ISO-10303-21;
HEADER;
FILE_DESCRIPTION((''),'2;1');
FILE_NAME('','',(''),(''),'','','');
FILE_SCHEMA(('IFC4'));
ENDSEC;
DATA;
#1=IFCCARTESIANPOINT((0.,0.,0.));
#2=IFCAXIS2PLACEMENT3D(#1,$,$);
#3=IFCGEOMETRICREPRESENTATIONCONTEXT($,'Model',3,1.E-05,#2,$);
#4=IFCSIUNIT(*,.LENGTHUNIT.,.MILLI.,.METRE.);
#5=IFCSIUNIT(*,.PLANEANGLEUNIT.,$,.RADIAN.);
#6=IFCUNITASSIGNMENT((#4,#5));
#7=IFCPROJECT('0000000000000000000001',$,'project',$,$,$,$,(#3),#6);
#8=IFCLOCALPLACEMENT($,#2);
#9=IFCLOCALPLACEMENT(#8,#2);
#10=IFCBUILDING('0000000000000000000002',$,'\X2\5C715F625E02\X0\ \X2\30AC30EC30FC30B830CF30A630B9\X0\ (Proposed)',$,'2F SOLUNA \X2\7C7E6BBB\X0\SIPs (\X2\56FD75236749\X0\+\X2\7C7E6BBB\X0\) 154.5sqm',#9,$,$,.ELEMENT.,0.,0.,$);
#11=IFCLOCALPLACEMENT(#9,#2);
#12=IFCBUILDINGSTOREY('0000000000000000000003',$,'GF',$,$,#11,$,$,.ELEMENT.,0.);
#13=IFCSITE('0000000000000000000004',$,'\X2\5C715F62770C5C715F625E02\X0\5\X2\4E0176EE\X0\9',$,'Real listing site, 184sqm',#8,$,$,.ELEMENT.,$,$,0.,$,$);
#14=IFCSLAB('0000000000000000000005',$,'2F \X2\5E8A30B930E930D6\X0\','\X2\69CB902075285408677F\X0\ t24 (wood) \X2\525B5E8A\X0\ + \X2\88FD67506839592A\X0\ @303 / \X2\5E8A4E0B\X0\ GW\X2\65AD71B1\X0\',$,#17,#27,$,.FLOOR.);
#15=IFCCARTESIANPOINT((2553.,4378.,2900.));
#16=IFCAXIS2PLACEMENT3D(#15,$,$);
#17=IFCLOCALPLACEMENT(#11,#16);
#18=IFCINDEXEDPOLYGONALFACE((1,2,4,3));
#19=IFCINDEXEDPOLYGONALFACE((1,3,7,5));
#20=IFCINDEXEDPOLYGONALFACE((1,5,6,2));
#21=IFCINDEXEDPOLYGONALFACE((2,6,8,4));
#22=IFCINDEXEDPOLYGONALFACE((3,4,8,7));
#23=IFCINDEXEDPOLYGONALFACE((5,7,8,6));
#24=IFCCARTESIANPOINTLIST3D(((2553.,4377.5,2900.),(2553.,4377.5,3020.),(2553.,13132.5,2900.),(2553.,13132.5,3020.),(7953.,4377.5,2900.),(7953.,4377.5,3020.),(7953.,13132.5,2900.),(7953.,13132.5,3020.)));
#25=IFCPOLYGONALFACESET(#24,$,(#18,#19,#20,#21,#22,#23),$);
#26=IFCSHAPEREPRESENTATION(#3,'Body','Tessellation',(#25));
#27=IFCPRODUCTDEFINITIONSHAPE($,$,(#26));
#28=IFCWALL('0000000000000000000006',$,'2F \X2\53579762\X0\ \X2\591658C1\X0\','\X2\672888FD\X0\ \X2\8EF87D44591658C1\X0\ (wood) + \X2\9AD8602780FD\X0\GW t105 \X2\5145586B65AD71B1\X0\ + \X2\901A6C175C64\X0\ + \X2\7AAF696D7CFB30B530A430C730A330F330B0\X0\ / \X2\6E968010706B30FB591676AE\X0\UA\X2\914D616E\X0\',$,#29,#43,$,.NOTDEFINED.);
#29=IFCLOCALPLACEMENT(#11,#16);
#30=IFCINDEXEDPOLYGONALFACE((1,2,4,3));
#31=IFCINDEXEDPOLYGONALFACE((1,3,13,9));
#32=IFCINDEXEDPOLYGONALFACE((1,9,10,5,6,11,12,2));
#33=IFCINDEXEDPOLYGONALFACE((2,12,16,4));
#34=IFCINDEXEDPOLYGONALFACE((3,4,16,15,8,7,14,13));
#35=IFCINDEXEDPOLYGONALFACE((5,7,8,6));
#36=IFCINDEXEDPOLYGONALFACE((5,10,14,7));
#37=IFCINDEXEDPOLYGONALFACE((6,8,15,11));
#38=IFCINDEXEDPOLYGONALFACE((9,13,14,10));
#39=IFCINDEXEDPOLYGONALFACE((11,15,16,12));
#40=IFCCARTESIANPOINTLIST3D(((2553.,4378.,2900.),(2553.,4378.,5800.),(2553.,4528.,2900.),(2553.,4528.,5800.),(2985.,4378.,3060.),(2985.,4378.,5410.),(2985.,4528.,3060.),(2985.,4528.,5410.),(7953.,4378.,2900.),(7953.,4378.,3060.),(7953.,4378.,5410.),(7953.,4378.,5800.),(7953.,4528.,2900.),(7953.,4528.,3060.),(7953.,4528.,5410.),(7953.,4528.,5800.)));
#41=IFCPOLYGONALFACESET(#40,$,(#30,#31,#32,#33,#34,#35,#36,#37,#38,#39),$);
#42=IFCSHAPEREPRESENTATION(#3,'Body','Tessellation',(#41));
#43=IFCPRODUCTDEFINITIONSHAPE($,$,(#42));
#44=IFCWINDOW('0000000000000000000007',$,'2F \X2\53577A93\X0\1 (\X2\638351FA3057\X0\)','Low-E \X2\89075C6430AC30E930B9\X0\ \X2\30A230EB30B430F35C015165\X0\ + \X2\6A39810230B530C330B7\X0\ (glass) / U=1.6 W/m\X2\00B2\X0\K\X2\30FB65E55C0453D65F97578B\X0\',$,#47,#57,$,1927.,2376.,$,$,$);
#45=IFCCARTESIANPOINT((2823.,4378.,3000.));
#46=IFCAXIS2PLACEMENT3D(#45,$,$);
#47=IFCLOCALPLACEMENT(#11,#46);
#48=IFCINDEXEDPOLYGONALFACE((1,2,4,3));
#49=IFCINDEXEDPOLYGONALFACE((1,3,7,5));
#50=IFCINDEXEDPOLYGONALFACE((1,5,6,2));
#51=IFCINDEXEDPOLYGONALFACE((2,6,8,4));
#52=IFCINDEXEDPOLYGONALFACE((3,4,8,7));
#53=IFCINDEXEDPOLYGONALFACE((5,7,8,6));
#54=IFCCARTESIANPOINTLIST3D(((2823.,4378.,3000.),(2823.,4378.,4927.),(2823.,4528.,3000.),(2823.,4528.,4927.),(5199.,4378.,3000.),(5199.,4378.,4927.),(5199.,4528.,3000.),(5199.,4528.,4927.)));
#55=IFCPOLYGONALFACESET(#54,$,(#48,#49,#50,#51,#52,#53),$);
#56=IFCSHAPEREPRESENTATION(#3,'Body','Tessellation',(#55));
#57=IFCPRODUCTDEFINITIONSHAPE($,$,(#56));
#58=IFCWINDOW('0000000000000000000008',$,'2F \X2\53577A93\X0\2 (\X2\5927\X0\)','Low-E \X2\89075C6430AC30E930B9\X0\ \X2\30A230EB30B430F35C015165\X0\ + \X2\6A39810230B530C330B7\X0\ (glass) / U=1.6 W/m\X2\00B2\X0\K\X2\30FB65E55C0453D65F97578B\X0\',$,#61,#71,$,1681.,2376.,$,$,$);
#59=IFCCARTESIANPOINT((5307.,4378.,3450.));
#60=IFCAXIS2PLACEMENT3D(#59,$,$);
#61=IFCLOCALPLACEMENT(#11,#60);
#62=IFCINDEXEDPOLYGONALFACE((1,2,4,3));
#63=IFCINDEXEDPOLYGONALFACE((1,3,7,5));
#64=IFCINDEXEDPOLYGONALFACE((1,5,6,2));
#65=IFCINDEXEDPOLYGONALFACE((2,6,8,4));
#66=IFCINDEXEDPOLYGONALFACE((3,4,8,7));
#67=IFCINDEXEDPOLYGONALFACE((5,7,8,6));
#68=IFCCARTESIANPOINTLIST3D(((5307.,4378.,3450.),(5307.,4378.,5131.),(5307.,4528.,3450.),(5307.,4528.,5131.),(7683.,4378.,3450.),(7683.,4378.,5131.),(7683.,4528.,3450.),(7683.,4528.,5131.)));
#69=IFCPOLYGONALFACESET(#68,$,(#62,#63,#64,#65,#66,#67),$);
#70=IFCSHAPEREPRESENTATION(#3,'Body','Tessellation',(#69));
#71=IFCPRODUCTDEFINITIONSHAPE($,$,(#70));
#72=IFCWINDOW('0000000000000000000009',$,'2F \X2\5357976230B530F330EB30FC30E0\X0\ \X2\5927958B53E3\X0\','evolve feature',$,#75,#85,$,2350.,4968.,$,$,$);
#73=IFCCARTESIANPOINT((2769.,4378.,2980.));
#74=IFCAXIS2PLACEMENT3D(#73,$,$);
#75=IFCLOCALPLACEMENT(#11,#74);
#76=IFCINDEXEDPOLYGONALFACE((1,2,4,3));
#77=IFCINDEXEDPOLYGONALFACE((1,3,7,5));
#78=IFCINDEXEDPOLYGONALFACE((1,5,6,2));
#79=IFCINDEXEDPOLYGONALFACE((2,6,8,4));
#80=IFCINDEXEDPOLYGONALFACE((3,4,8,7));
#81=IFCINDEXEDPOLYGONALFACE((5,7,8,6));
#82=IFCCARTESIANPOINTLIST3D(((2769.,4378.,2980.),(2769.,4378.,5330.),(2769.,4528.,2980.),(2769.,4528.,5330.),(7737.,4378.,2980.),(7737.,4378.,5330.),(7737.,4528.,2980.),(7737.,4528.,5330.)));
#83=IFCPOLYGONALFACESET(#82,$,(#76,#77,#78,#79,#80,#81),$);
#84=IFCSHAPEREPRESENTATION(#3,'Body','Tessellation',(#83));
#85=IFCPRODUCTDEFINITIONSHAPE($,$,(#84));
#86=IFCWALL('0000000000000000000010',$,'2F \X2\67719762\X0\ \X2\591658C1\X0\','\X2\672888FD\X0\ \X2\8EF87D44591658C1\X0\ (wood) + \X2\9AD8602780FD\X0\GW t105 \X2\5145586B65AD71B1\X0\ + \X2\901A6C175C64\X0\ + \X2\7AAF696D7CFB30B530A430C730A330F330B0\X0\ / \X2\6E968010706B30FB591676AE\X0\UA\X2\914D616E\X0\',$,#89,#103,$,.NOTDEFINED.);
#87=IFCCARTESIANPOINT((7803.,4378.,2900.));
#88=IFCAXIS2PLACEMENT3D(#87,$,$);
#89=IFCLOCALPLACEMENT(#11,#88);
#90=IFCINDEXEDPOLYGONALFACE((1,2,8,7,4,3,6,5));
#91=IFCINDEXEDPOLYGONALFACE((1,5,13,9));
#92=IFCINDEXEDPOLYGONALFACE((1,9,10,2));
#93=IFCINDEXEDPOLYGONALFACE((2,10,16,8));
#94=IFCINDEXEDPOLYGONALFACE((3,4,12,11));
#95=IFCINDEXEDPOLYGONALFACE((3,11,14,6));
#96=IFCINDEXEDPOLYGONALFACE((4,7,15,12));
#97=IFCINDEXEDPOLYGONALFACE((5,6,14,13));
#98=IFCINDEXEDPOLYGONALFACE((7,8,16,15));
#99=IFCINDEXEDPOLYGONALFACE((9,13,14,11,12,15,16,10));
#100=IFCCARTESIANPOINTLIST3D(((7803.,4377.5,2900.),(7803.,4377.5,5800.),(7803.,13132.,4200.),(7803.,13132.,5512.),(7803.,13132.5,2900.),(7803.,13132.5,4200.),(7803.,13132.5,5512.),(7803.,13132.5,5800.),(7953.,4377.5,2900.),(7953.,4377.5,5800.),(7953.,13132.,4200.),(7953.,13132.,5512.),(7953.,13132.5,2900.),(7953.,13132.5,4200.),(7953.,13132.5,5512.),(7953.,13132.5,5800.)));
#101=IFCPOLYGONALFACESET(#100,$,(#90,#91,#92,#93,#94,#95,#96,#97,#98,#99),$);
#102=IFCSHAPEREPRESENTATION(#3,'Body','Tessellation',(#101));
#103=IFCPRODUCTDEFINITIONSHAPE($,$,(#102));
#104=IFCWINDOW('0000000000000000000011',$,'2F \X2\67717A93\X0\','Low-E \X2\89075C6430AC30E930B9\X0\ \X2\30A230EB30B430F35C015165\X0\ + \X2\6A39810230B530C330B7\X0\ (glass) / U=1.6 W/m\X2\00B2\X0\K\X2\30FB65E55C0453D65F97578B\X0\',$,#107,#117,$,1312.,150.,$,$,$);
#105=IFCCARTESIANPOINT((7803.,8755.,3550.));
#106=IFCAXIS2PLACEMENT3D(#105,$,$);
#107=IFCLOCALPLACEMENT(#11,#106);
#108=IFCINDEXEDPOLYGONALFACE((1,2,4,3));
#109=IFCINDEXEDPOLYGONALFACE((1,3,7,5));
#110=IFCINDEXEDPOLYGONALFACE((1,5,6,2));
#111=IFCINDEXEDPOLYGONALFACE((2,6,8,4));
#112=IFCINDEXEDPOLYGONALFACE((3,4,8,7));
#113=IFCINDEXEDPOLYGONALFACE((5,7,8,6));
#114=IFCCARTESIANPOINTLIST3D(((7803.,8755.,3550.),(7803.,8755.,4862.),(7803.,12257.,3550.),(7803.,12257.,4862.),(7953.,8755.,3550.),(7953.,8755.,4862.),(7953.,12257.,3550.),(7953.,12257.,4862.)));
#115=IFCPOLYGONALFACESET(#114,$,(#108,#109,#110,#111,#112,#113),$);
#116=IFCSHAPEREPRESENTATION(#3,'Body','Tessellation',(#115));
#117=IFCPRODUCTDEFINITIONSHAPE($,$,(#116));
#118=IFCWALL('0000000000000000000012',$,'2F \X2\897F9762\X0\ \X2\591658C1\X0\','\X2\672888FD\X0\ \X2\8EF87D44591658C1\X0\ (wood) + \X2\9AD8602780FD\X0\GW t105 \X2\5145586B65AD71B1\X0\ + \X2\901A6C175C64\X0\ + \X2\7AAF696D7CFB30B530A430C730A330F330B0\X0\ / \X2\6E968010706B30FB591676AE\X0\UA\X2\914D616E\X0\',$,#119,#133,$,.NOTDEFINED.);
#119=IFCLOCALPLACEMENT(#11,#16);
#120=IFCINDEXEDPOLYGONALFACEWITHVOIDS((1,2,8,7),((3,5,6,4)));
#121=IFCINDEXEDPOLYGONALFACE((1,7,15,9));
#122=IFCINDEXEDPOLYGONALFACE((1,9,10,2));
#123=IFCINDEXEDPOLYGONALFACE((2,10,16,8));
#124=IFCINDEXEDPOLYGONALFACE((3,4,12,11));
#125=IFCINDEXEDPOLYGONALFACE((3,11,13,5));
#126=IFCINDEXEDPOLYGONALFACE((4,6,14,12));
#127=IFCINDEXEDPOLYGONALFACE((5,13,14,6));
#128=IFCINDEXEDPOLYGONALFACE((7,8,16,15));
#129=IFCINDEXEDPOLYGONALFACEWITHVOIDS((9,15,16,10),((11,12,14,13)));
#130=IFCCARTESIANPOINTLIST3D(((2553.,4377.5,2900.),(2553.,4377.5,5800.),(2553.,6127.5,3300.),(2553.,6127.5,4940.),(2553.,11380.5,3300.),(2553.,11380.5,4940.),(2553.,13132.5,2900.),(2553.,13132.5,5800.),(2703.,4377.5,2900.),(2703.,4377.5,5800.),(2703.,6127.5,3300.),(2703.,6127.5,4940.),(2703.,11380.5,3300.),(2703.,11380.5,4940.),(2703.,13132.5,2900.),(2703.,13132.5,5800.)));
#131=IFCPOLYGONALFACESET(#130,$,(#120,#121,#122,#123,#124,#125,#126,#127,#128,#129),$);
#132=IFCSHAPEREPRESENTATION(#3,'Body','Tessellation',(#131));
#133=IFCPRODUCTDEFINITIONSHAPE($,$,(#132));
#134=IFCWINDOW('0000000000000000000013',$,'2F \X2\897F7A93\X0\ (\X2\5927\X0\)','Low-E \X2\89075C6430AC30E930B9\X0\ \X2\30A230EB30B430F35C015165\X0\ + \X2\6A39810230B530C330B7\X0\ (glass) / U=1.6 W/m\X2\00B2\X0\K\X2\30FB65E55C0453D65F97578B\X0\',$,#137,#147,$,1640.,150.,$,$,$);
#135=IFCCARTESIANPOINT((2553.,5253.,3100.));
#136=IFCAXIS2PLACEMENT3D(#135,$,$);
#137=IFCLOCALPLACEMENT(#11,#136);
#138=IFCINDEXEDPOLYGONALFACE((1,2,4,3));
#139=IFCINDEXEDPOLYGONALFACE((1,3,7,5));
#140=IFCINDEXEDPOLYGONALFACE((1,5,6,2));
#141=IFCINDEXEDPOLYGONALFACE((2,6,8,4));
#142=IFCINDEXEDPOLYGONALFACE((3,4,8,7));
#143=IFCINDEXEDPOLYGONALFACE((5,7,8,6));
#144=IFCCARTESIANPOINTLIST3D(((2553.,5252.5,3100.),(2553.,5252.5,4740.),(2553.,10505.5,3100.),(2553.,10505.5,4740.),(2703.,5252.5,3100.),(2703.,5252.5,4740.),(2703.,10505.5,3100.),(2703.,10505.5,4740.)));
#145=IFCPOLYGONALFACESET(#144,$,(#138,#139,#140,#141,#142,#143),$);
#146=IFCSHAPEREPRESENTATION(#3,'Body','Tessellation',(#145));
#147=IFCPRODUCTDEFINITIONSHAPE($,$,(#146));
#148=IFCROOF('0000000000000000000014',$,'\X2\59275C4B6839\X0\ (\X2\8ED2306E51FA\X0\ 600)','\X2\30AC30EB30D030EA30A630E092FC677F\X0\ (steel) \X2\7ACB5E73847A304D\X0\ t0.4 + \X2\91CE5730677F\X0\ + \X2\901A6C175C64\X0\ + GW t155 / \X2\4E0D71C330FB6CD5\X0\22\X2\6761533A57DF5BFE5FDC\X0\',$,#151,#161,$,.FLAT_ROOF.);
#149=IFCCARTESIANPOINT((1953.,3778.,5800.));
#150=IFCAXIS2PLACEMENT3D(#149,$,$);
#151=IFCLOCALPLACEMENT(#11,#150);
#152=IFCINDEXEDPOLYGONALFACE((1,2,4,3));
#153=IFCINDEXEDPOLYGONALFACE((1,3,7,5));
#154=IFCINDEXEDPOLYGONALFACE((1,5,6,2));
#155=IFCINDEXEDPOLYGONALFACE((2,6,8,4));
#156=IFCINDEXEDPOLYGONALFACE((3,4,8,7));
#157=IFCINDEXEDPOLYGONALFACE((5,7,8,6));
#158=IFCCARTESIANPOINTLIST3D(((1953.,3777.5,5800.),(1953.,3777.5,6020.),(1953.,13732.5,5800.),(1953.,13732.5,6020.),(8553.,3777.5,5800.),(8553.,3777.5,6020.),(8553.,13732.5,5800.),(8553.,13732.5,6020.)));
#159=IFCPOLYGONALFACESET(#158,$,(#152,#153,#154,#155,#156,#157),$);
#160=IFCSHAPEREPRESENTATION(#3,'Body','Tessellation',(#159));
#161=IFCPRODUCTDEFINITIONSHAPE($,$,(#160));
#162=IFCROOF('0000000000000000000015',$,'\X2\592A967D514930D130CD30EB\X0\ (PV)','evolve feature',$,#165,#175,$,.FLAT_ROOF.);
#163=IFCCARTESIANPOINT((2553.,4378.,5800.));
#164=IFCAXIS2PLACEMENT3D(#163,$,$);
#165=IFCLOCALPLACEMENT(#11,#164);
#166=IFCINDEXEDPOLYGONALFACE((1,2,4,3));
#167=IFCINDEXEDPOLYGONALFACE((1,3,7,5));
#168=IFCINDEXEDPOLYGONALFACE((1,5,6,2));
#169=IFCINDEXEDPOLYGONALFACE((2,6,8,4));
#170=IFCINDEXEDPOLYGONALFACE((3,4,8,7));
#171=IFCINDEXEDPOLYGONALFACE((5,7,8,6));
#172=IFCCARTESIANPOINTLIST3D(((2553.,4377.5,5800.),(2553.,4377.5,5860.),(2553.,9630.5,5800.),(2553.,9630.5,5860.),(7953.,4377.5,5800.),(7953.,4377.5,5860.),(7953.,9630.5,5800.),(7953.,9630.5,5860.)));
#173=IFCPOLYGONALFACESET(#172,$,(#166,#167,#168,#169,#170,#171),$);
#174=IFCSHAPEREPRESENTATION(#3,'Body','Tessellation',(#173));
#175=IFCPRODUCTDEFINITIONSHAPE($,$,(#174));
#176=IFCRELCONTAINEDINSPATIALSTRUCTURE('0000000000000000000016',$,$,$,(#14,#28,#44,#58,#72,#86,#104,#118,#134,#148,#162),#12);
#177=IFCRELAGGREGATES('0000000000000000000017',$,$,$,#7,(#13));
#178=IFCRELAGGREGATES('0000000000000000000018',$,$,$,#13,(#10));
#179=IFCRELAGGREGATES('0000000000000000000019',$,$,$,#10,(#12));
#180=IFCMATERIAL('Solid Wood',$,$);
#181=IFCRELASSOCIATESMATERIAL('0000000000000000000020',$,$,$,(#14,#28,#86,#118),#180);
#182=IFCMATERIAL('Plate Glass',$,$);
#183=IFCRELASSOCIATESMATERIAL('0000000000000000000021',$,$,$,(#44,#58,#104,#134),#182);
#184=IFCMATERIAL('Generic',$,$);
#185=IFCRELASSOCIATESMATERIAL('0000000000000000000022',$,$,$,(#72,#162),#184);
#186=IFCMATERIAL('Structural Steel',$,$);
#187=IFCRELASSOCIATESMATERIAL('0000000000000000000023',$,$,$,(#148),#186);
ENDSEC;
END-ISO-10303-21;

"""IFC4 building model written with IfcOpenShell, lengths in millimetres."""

from ifc_helpers import new_model, si_unit, frame, frame_2d, origin, place, context, project, spatial, rectangle, extrude, material, element, fill, save


model = new_model("IFC4")

# Units and contexts
model_context = context("Model", 3, precision=1e-05, world=origin())
ifc_project = project(units=[si_unit("LENGTHUNIT", "METRE", prefix="MILLI"), si_unit("PLANEANGLEUNIT", "RADIAN")], contexts=[model_context])

# Site, building, storey
site_placement = place(None, origin())
site = spatial("IfcSite", under=ifc_project, at=site_placement, Name="山形県山形市5丁目9", ObjectType="Real listing site, 184sqm", CompositionType="ELEMENT", RefElevation=0.0)
building_placement = place(site_placement, origin())
building = spatial("IfcBuilding", under=site, at=building_placement, Name="山形市 ガレージハウス (Proposed)", ObjectType="2F SOLUNA 籾殻SIPs (国産杉+籾殻) 154.5sqm", CompositionType="ELEMENT", ElevationOfRefHeight=0.0, ElevationOfTerrain=0.0)
storey_placement = place(building_placement, origin())
storey = spatial("IfcBuildingStorey", under=building, at=storey_placement, Name="GF", CompositionType="ELEMENT", Elevation=0.0)

# Slab
ifc_material_1 = material(Name="Solid Wood")
slab_placement = place(storey_placement, frame((2553.0, 4378.0, 2900.0)))
element("IfcSlab", 1, at=slab_placement, inside=storey, material=ifc_material_1, Name="2F 床スラブ", Description="構造用合板 t24 (wood) 剛床 + 製材根太 @303 / 床下 GW断熱", PredefinedType="FLOOR", context=model_context, shape_type="SweptSolid", body=[
    extrude(rectangle(XDim=5400.0, YDim=8755.0, at=frame_2d((2700.0, 4377.0))), frame((2553.0, 4378.0, 2900.0)), (0.0, 0.0, 1.0), 120.0),
])

# Wall, openings, windows
wall_1_placement = place(storey_placement, frame((2553.0, 4378.0, 2900.0)))
wall_1 = element("IfcWall", 2, at=wall_1_placement, inside=storey, material=ifc_material_1, Name="2F 南面 外壁", Description="木製 軸組外壁 (wood) + 高性能GW t105 充填断熱 + 通気層 + 窯業系サイディング / 準耐火・外皮UA配慮", PredefinedType="NOTDEFINED", context=model_context, shape_type="SweptSolid", body=[
    extrude(rectangle(XDim=5400.0, YDim=150.0, at=frame_2d((2700.0, 75.0))), frame((2553.0, 4378.0, 2900.0)), (0.0, 0.0, 1.0), 2900.0),
])
opening_1_placement = place(storey_placement, frame((2823.0, 4378.0, 3000.0)))
opening_1 = element("IfcOpeningElement", 3, at=opening_1_placement, cuts=wall_1, PredefinedType="NOTDEFINED", context=model_context, shape_type="SweptSolid", body=[
    extrude(rectangle(XDim=2376.0, YDim=150.0, at=frame_2d((1188.0, 75.0))), frame((2823.0, 4378.0, 3000.0)), (0.0, 0.0, 1.0), 1927.0),
])
opening_2_placement = place(storey_placement, frame((5307.0, 4378.0, 3450.0)))
opening_2 = element("IfcOpeningElement", 4, at=opening_2_placement, cuts=wall_1, PredefinedType="NOTDEFINED", context=model_context, shape_type="SweptSolid", body=[
    extrude(rectangle(XDim=2376.0, YDim=150.0, at=frame_2d((1188.0, 75.0))), frame((5307.0, 4378.0, 3450.0)), (0.0, 0.0, 1.0), 1681.0),
])
opening_3_placement = place(storey_placement, frame((2769.0, 4378.0, 2980.0)))
opening_3 = element("IfcOpeningElement", 5, at=opening_3_placement, cuts=wall_1, PredefinedType="NOTDEFINED", context=model_context, shape_type="SweptSolid", body=[
    extrude(rectangle(XDim=4968.0, YDim=150.0, at=frame_2d((2484.0, 75.0))), frame((2769.0, 4378.0, 2980.0)), (0.0, 0.0, 1.0), 2350.0),
])
ifc_material_2 = material(Name="Plate Glass")
window_1_placement = place(storey_placement, frame((2823.0, 4378.0, 3000.0)))
window_1 = element("IfcWindow", 6, at=window_1_placement, inside=storey, material=ifc_material_2, Name="2F 南窓1 (掃出し)", Description="Low-E 複層ガラス アルゴン封入 + 樹脂サッシ (glass) / U=1.6 W/m²K・日射取得型", OverallHeight=1927.0, OverallWidth=2376.0, context=model_context, shape_type="SweptSolid", body=[
    extrude(rectangle(XDim=2376.0, YDim=150.0, at=frame_2d((1188.0, 75.0))), frame((2823.0, 4378.0, 3000.0)), (0.0, 0.0, 1.0), 1927.0),
])
fill(opening_1, window_1)
window_2_placement = place(storey_placement, frame((5307.0, 4378.0, 3450.0)))
window_2 = element("IfcWindow", 7, at=window_2_placement, inside=storey, material=ifc_material_2, Name="2F 南窓2 (大)", Description="Low-E 複層ガラス アルゴン封入 + 樹脂サッシ (glass) / U=1.6 W/m²K・日射取得型", OverallHeight=1681.0, OverallWidth=2376.0, context=model_context, shape_type="SweptSolid", body=[
    extrude(rectangle(XDim=2376.0, YDim=150.0, at=frame_2d((1188.0, 75.0))), frame((5307.0, 4378.0, 3450.0)), (0.0, 0.0, 1.0), 1681.0),
])
fill(opening_2, window_2)
ifc_material_3 = material(Name="Generic")
window_3_placement = place(storey_placement, frame((2769.0, 4378.0, 2980.0)))
window_3 = element("IfcWindow", 8, at=window_3_placement, inside=storey, material=ifc_material_3, Name="2F 南面サンルーム 大開口", Description="evolve feature", OverallHeight=2350.0, OverallWidth=4968.0, context=model_context, shape_type="SweptSolid", body=[
    extrude(rectangle(XDim=4968.0, YDim=150.0, at=frame_2d((2484.0, 75.0))), frame((2769.0, 4378.0, 2980.0)), (0.0, 0.0, 1.0), 2350.0),
])
fill(opening_3, window_3)

# Walls, openings, windows
wall_2_placement = place(storey_placement, frame((7803.0, 4378.0, 2900.0)))
wall_2 = element("IfcWall", 9, at=wall_2_placement, inside=storey, material=ifc_material_1, Name="2F 東面 外壁", Description="木製 軸組外壁 (wood) + 高性能GW t105 充填断熱 + 通気層 + 窯業系サイディング / 準耐火・外皮UA配慮", PredefinedType="NOTDEFINED", context=model_context, shape_type="SweptSolid", body=[
    extrude(rectangle(XDim=150.0, YDim=8755.0, at=frame_2d((75.0, 4377.0))), frame((7803.0, 4378.0, 2900.0)), (0.0, 0.0, 1.0), 2900.0),
])
opening_4_placement = place(storey_placement, frame((7803.0, 8755.0, 3550.0)))
opening_4 = element("IfcOpeningElement", 10, at=opening_4_placement, cuts=wall_2, PredefinedType="NOTDEFINED", context=model_context, shape_type="SweptSolid", body=[
    extrude(rectangle(XDim=150.0, YDim=3502.0, at=frame_2d((75.0, 1751.0))), frame((7803.0, 8755.0, 3550.0)), (0.0, 0.0, 1.0), 1312.0),
])
window_4_placement = place(storey_placement, frame((7803.0, 8755.0, 3550.0)))
window_4 = element("IfcWindow", 11, at=window_4_placement, inside=storey, material=ifc_material_2, Name="2F 東窓", Description="Low-E 複層ガラス アルゴン封入 + 樹脂サッシ (glass) / U=1.6 W/m²K・日射取得型", OverallHeight=1312.0, OverallWidth=150.0, context=model_context, shape_type="SweptSolid", body=[
    extrude(rectangle(XDim=150.0, YDim=3502.0, at=frame_2d((75.0, 1751.0))), frame((7803.0, 8755.0, 3550.0)), (0.0, 0.0, 1.0), 1312.0),
])
fill(opening_4, window_4)
wall_3_placement = place(storey_placement, frame((2553.0, 4378.0, 2900.0)))
wall_3 = element("IfcWall", 12, at=wall_3_placement, inside=storey, material=ifc_material_1, Name="2F 西面 外壁", Description="木製 軸組外壁 (wood) + 高性能GW t105 充填断熱 + 通気層 + 窯業系サイディング / 準耐火・外皮UA配慮", PredefinedType="NOTDEFINED", context=model_context, shape_type="SweptSolid", body=[
    extrude(rectangle(XDim=150.0, YDim=8755.0, at=frame_2d((75.0, 4377.0))), frame((2553.0, 4378.0, 2900.0)), (0.0, 0.0, 1.0), 2900.0),
])
opening_5_placement = place(storey_placement, frame((2553.0, 5253.0, 3100.0)))
opening_5 = element("IfcOpeningElement", 13, at=opening_5_placement, cuts=wall_3, PredefinedType="NOTDEFINED", context=model_context, shape_type="SweptSolid", body=[
    extrude(rectangle(XDim=150.0, YDim=5253.0, at=frame_2d((75.0, 2626.0))), frame((2553.0, 5253.0, 3100.0)), (0.0, 0.0, 1.0), 1640.0),
])
window_5_placement = place(storey_placement, frame((2553.0, 5253.0, 3100.0)))
window_5 = element("IfcWindow", 14, at=window_5_placement, inside=storey, material=ifc_material_2, Name="2F 西窓 (大)", Description="Low-E 複層ガラス アルゴン封入 + 樹脂サッシ (glass) / U=1.6 W/m²K・日射取得型", OverallHeight=1640.0, OverallWidth=150.0, context=model_context, shape_type="SweptSolid", body=[
    extrude(rectangle(XDim=150.0, YDim=5253.0, at=frame_2d((75.0, 2626.0))), frame((2553.0, 5253.0, 3100.0)), (0.0, 0.0, 1.0), 1640.0),
])
fill(opening_5, window_5)

# Roofs
ifc_material_4 = material(Name="Structural Steel")
roof_1_placement = place(storey_placement, frame((1953.0, 3778.0, 5800.0)))
element("IfcRoof", 15, at=roof_1_placement, inside=storey, material=ifc_material_4, Name="大屋根 (軒の出 600)", Description="ガルバリウム鋼板 (steel) 立平葺き t0.4 + 野地板 + 通気層 + GW t155 / 不燃・法22条区域対応", PredefinedType="FLAT_ROOF", context=model_context, shape_type="SweptSolid", body=[
    extrude(rectangle(XDim=6600.0, YDim=9955.0, at=frame_2d((3300.0, 4977.0))), frame((1953.0, 3778.0, 5800.0)), (0.0, 0.0, 1.0), 220.0),
])
roof_2_placement = place(storey_placement, frame((2553.0, 4378.0, 5800.0)))
element("IfcRoof", 16, at=roof_2_placement, inside=storey, material=ifc_material_3, Name="太陽光パネル (PV)", Description="evolve feature", PredefinedType="FLAT_ROOF", context=model_context, shape_type="SweptSolid", body=[
    extrude(rectangle(XDim=5400.0, YDim=5253.0, at=frame_2d((2700.0, 2626.0))), frame((2553.0, 4378.0, 5800.0)), (0.0, 0.0, 1.0), 60.0),
])

save(model, "model.ifc")
